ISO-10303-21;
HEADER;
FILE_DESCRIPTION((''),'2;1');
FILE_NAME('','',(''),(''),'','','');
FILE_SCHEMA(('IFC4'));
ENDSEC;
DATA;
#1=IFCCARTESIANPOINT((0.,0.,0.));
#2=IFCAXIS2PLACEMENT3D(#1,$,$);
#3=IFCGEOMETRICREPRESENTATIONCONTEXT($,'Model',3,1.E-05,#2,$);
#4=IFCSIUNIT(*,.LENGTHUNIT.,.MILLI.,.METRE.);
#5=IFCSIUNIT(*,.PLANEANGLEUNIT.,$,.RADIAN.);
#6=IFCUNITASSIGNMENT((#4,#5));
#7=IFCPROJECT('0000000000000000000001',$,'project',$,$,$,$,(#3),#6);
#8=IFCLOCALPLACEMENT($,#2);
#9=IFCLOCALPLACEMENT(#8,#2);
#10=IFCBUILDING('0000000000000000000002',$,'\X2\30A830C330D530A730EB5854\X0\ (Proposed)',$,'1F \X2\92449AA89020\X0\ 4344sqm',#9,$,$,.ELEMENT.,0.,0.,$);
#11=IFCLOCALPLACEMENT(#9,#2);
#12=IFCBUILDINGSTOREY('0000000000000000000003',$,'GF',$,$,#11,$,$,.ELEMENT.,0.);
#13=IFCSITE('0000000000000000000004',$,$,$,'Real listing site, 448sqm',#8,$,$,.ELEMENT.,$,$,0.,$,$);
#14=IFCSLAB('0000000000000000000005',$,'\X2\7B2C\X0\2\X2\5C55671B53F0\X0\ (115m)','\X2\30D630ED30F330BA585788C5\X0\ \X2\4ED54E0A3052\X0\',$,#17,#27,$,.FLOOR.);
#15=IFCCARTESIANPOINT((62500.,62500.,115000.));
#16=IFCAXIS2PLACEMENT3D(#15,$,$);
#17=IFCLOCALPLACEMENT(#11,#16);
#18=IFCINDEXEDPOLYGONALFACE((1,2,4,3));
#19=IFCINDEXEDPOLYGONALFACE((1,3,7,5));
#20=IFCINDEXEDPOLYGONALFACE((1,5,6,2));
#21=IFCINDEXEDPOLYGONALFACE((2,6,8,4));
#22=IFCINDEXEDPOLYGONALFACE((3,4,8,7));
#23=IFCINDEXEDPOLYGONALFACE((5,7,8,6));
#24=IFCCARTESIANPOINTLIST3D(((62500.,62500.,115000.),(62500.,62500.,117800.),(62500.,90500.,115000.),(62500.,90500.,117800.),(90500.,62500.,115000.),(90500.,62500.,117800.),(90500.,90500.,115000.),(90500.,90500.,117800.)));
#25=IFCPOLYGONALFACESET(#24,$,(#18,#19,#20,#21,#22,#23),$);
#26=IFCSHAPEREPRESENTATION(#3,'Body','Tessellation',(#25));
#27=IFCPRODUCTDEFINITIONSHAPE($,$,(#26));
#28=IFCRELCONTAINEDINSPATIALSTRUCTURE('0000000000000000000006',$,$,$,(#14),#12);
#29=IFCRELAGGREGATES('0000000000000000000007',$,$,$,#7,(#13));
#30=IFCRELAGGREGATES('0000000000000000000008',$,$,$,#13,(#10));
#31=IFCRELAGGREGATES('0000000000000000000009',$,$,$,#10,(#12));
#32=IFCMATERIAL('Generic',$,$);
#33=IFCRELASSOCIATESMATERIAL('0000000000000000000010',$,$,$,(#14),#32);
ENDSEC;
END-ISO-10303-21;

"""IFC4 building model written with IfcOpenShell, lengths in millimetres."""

from ifc_helpers import new_model, si_unit, frame, frame_2d, origin, place, context, project, spatial, rectangle, extrude, material, element, save


model = new_model("IFC4")

# Units and contexts
model_context = context("Model", 3, precision=1e-05, world=origin())
ifc_project = project(units=[si_unit("LENGTHUNIT", "METRE", prefix="MILLI"), si_unit("PLANEANGLEUNIT", "RADIAN")], contexts=[model_context])

# Site, building, storey
site_placement = place(None, origin())
site = spatial("IfcSite", under=ifc_project, at=site_placement, ObjectType="Real listing site, 448sqm", CompositionType="ELEMENT", RefElevation=0.0)
building_placement = place(site_placement, origin())
building = spatial("IfcBuilding", under=site, at=building_placement, Name="エッフェル塔 (Proposed)", ObjectType="1F 鉄骨造 4344sqm", CompositionType="ELEMENT", ElevationOfRefHeight=0.0, ElevationOfTerrain=0.0)
storey_placement = place(building_placement, origin())
storey = spatial("IfcBuildingStorey", under=building, at=storey_placement, Name="GF", CompositionType="ELEMENT", Elevation=0.0)

# Shared definitions
ifc_material = material(Name="Generic")

# Slab
slab_placement = place(storey_placement, frame((62500.0, 62500.0, 115000.0)))
element("IfcSlab", 1, at=slab_placement, inside=storey, material=ifc_material, Name="第2展望台 (115m)", Description="ブロンズ塗装 仕上げ", PredefinedType="FLOOR", context=model_context, shape_type="SweptSolid", body=[
    extrude(rectangle(XDim=28000.0, YDim=28000.0, at=frame_2d((14000.0, 14000.0))), frame((62500.0, 62500.0, 115000.0)), (0.0, 0.0, 1.0), 2800.0),
])

save(model, "model.ifc")
